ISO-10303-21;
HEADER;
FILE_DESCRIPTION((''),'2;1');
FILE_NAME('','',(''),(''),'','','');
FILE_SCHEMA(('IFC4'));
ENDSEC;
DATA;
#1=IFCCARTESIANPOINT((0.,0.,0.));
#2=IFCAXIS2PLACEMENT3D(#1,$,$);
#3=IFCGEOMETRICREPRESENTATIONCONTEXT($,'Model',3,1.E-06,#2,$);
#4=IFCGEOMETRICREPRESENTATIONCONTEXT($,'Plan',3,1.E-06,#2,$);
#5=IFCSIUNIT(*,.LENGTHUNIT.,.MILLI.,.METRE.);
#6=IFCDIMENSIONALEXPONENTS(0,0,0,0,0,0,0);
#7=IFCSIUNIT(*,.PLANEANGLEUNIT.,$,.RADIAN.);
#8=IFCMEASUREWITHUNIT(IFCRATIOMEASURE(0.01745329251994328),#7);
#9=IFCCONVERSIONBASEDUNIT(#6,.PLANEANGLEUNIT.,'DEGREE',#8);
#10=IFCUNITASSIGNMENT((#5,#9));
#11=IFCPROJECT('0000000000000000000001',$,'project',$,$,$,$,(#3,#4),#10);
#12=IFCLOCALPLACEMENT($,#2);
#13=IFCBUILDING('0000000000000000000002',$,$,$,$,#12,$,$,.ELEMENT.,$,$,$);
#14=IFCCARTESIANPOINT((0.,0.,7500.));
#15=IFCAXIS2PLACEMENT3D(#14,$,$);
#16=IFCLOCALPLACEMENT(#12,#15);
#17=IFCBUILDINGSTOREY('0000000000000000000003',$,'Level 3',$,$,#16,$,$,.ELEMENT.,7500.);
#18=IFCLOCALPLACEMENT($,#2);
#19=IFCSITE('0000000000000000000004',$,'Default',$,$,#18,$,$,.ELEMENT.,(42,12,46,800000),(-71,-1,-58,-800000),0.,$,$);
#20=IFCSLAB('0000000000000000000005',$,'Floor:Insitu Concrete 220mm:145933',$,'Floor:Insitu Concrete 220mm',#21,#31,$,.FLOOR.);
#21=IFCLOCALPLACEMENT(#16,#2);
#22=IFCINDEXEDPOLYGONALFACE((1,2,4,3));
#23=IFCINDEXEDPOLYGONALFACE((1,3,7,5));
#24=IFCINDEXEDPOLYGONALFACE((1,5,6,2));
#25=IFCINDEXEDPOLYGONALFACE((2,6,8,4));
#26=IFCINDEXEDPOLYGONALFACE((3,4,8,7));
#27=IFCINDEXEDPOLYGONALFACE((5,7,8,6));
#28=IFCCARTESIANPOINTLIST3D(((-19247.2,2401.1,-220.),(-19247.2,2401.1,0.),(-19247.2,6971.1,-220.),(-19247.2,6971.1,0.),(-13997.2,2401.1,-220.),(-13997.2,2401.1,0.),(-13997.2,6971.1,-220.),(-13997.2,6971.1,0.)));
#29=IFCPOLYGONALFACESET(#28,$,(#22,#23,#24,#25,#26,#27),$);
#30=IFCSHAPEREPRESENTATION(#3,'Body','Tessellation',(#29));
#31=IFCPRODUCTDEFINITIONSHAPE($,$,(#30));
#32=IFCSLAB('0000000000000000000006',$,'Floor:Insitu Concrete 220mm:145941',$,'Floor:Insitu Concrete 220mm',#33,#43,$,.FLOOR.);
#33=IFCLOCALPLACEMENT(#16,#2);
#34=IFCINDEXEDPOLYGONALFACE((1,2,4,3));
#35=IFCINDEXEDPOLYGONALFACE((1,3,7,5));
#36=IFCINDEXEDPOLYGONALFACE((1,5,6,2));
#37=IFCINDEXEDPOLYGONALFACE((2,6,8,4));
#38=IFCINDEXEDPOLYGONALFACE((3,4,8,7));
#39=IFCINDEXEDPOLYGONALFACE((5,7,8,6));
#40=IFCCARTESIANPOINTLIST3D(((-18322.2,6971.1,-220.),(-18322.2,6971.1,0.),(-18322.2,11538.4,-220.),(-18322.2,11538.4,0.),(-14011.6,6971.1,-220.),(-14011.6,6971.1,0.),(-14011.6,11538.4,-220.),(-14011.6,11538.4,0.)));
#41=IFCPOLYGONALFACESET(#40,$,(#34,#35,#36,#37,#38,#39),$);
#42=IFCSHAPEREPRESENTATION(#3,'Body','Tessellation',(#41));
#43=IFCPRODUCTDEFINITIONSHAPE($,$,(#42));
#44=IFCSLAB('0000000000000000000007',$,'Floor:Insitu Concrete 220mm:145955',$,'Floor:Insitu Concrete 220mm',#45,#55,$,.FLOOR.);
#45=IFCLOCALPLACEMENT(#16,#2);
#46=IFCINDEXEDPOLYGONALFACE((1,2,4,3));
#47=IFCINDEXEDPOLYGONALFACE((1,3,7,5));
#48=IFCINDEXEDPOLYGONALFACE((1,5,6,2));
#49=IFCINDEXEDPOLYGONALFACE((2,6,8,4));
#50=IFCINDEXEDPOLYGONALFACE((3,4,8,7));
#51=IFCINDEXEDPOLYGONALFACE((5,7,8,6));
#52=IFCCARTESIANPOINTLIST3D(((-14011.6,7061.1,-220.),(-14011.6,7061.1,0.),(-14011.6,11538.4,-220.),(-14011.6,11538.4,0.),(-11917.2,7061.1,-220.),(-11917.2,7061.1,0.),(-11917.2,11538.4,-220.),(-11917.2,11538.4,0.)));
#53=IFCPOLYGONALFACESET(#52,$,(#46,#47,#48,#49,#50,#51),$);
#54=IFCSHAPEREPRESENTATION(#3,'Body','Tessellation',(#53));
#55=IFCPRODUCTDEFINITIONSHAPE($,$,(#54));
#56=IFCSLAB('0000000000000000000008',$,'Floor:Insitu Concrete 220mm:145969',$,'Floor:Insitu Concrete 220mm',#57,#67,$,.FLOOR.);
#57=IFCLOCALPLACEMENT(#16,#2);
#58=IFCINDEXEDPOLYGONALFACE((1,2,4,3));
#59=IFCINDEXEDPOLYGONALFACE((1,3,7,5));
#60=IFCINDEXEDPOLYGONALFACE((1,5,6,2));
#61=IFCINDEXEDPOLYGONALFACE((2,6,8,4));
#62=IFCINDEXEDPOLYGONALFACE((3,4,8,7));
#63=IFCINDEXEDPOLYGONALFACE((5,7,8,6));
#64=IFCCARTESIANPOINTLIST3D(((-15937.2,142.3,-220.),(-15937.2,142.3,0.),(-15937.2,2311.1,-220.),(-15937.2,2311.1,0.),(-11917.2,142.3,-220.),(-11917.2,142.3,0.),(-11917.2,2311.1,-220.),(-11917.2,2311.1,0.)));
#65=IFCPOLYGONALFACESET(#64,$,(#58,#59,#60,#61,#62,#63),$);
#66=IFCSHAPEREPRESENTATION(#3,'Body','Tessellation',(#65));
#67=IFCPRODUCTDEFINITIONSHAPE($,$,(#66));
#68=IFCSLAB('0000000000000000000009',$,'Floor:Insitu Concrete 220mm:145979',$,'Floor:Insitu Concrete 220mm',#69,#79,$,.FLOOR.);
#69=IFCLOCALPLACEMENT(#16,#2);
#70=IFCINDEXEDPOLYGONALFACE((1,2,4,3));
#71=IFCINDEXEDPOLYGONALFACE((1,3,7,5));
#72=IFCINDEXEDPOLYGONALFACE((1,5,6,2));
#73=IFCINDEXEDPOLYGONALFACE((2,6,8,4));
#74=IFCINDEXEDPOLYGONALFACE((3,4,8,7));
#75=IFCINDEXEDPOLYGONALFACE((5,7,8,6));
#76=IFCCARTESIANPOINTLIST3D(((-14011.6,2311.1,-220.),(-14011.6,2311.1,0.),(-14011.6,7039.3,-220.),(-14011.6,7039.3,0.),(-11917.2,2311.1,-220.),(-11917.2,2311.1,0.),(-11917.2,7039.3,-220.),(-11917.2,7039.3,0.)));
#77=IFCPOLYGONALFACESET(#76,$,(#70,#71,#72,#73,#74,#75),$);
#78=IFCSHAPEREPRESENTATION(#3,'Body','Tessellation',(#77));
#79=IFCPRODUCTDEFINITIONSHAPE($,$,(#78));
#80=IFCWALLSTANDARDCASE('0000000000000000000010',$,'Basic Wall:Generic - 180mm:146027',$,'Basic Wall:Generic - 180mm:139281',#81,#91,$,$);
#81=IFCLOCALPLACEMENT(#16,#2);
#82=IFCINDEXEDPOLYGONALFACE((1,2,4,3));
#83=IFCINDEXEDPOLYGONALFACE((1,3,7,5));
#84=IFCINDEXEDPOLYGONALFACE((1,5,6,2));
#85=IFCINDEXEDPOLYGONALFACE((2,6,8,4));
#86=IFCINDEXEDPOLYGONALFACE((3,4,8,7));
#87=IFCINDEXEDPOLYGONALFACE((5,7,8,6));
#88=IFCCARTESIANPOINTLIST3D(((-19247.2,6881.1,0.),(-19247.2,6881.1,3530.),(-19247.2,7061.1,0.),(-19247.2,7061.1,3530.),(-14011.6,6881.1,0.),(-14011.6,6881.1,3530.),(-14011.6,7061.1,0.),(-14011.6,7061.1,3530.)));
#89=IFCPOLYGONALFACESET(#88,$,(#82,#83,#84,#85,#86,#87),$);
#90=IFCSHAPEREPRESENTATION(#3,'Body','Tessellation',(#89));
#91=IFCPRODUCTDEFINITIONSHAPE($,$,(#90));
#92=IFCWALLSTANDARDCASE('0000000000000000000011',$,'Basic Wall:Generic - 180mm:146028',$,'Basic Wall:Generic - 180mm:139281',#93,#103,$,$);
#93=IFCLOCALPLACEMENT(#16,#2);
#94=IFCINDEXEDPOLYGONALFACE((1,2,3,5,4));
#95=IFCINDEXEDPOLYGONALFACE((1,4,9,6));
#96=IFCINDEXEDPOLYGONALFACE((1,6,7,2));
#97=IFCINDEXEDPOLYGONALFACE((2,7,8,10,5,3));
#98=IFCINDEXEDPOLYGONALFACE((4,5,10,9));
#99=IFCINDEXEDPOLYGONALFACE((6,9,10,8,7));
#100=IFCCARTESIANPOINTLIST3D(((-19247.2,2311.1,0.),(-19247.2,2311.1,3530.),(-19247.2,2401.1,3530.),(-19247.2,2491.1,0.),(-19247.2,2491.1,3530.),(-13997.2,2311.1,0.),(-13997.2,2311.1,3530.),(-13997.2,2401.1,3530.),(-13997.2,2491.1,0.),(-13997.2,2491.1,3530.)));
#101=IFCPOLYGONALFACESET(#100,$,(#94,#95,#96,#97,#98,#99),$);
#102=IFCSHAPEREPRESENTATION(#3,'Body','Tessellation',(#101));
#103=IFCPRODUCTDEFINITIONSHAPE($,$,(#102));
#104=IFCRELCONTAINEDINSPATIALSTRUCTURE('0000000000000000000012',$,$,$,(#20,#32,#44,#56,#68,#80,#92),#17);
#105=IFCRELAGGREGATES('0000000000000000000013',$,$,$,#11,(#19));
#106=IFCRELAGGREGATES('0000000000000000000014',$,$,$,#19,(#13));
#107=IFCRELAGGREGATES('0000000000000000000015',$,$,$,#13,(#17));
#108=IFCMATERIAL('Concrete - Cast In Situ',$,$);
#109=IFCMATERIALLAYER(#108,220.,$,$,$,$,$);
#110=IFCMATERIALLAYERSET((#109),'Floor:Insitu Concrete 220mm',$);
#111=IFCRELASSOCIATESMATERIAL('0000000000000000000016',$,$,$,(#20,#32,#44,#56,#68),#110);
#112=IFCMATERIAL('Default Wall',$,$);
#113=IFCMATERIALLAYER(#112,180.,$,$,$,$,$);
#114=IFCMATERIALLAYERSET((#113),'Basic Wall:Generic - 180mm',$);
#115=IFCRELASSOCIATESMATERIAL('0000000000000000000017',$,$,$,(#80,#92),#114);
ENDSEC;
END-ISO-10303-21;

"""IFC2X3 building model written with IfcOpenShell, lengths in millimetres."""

from ifc_helpers import new_model, entity, si_unit, converted_unit, frame, frame_2d, origin, place, context, project, spatial, polyline, rectangle, extrude, clip, bounded_halfspace, material, layer, layer_set, layer_usage, element, save


model = new_model("IFC2X3")

# Units and contexts
model_context = context("Model", 3, precision=1e-06, world=origin())
plan_context = context("Plan", 3, precision=1e-06, world=origin())
ifc_project = project(units=[si_unit("LENGTHUNIT", "METRE", prefix="MILLI"), converted_unit("PLANEANGLEUNIT", "DEGREE", entity("IfcRatioMeasure", 0.01745329251994328), si_unit("PLANEANGLEUNIT", "RADIAN"), dimensions=[0, 0, 0, 0, 0, 0, 0])], contexts=[model_context, plan_context])

# Site, building, storey
site_placement = place(None, origin())
site = spatial("IfcSite", under=ifc_project, at=site_placement, Name="Default", CompositionType="ELEMENT", RefLatitude=(42, 12, 46, 800000), RefLongitude=(-71, -1, -58, -800000), RefElevation=0.0)
building_placement = place(None, origin())
building = spatial("IfcBuilding", under=site, at=building_placement, CompositionType="ELEMENT")
storey_placement = place(building_placement, frame((0.0, 0.0, 7500.0)))
storey = spatial("IfcBuildingStorey", under=building, at=storey_placement, Name="Level 3", CompositionType="ELEMENT", Elevation=7500.0)

# Slabs
ifc_material_1 = material(Name="Concrete - Cast In Situ")
ifc_layer_1 = layer(ifc_material_1, 220.0)
ifc_layer_set_1 = layer_set([ifc_layer_1], Name="Floor:Insitu Concrete 220mm")
ifc_layer_usage_1 = layer_usage(ifc_layer_set_1, "AXIS3", "POSITIVE", 0.0)
slab_1_placement = place(storey_placement, frame((-19247.2, 2401.1, -220.0)))
element("IfcSlab", 1, at=slab_1_placement, inside=storey, material=ifc_layer_usage_1, Name="Floor:Insitu Concrete 220mm:145933", ObjectType="Floor:Insitu Concrete 220mm", PredefinedType="FLOOR", context=model_context, shape_type="SweptSolid", body=[
    extrude(rectangle(XDim=4570.0, YDim=5250.0, at=frame_2d((16622.2, 4686.1), x_axis=(0.0, -1.0))), frame((19247.2, -2401.1, 220.0), z_axis=(0.0, 0.0, -1.0), x_axis=(-1.0, 0.0, 0.0)), (0.0, 0.0, 1.0), 220.0),
])
ifc_layer_usage_2 = layer_usage(ifc_layer_set_1, "AXIS3", "POSITIVE", 0.0)
slab_2_placement = place(storey_placement, frame((-18322.2, 6971.1, -220.0)))
element("IfcSlab", 2, at=slab_2_placement, inside=storey, material=ifc_layer_usage_2, Name="Floor:Insitu Concrete 220mm:145941", ObjectType="Floor:Insitu Concrete 220mm", PredefinedType="FLOOR", context=model_context, shape_type="SweptSolid", body=[
    extrude(rectangle(XDim=4567.3, YDim=4310.6, at=frame_2d((16166.9, 9254.7), x_axis=(0.0, -1.0))), frame((18322.2, -6971.1, 220.0), z_axis=(0.0, 0.0, -1.0), x_axis=(-1.0, 0.0, 0.0)), (0.0, 0.0, 1.0), 220.0),
])
ifc_layer_usage_3 = layer_usage(ifc_layer_set_1, "AXIS3", "POSITIVE", 0.0)
slab_3_placement = place(storey_placement, frame((-14011.6, 7061.1, -220.0)))
element("IfcSlab", 3, at=slab_3_placement, inside=storey, material=ifc_layer_usage_3, Name="Floor:Insitu Concrete 220mm:145955", ObjectType="Floor:Insitu Concrete 220mm", PredefinedType="FLOOR", context=model_context, shape_type="SweptSolid", body=[
    extrude(rectangle(XDim=4477.3, YDim=2094.4, at=frame_2d((12964.4, 9299.7), x_axis=(0.0, -1.0))), frame((14011.6, -7061.1, 220.0), z_axis=(0.0, 0.0, -1.0), x_axis=(-1.0, 0.0, 0.0)), (0.0, 0.0, 1.0), 220.0),
])
ifc_layer_usage_4 = layer_usage(ifc_layer_set_1, "AXIS3", "POSITIVE", 0.0)
slab_4_placement = place(storey_placement, frame((-15937.2, 142.3, -220.0)))
element("IfcSlab", 4, at=slab_4_placement, inside=storey, material=ifc_layer_usage_4, Name="Floor:Insitu Concrete 220mm:145969", ObjectType="Floor:Insitu Concrete 220mm", PredefinedType="FLOOR", context=model_context, shape_type="SweptSolid", body=[
    extrude(rectangle(XDim=2168.8, YDim=4020.0, at=frame_2d((13927.2, 1226.7), x_axis=(0.0, -1.0))), frame((15937.2, -142.3, 220.0), z_axis=(0.0, 0.0, -1.0), x_axis=(-1.0, 0.0, 0.0)), (0.0, 0.0, 1.0), 220.0),
])
ifc_layer_usage_5 = layer_usage(ifc_layer_set_1, "AXIS3", "POSITIVE", 0.0)
slab_5_placement = place(storey_placement, frame((-14011.6, 2311.1, -220.0)))
element("IfcSlab", 5, at=slab_5_placement, inside=storey, material=ifc_layer_usage_5, Name="Floor:Insitu Concrete 220mm:145979", ObjectType="Floor:Insitu Concrete 220mm", PredefinedType="FLOOR", context=model_context, shape_type="SweptSolid", body=[
    extrude(rectangle(XDim=4728.2, YDim=2094.4, at=frame_2d((12964.4, 4675.2), x_axis=(0.0, -1.0))), frame((14011.6, -2311.1, 220.0), z_axis=(0.0, 0.0, -1.0), x_axis=(-1.0, 0.0, 0.0)), (0.0, 0.0, 1.0), 220.0),
])

# Walls
ifc_material_2 = material(Name="Default Wall")
ifc_layer_2 = layer(ifc_material_2, 180.0)
ifc_layer_set_2 = layer_set([ifc_layer_2], Name="Basic Wall:Generic - 180mm")
ifc_layer_usage_6 = layer_usage(ifc_layer_set_2, "AXIS2", "POSITIVE", -90.0)
wall_1_placement = place(storey_placement, frame((-19247.2, 6971.1, 0.0)))
element("IfcWallStandardCase", 6, at=wall_1_placement, inside=storey, material=ifc_layer_usage_6, Name="Basic Wall:Generic - 180mm:146027", ObjectType="Basic Wall:Generic - 180mm:139281", context=model_context, shape_type="Clipping", body=[
    clip(extrude(rectangle(XDim=5235.6, YDim=180.0, at=frame_2d((2617.8, 0.0), x_axis=(-1.0, 0.0))), origin(), (0.0, 0.0, 1.0), 3750.0), bounded_halfspace(frame((0.0, -90.0, 3530.0), z_axis=(0.0, 0.0, 1.0), x_axis=(0.0, 1.0, 0.0)), False, frame((0.0, -90.0, 3530.0)), polyline([(0.0, 0.0), (5235.6, 0.0), (5235.6, 90.0), (5235.6, 180.0), (0.0, 180.0), (0.0, 90.0), (0.0, 0.0)]))),
])
ifc_layer_usage_7 = layer_usage(ifc_layer_set_2, "AXIS2", "POSITIVE", -90.0)
wall_2_placement = place(storey_placement, frame((-13997.2, 2401.1, 0.0), z_axis=(0.0, 0.0, 1.0), x_axis=(-1.0, 0.0, 0.0)))
element("IfcWallStandardCase", 7, at=wall_2_placement, inside=storey, material=ifc_layer_usage_7, Name="Basic Wall:Generic - 180mm:146028", ObjectType="Basic Wall:Generic - 180mm:139281", context=model_context, shape_type="Clipping", body=[
    clip(clip(clip(extrude(rectangle(XDim=5250.0, YDim=180.0, at=frame_2d((2625.0, 0.0), x_axis=(-1.0, 0.0))), origin(), (0.0, 0.0, 1.0), 3750.0), bounded_halfspace(frame((0.0, -90.0, 3530.0), z_axis=(0.0, 0.0, -1.0), x_axis=(0.0, 1.0, 0.0)), True, frame((0.0, -90.0, 3530.0)), polyline([(0.0, 0.0), (5250.0, 0.0), (5250.0, 90.0), (0.0, 90.0), (0.0, 0.0)]))), bounded_halfspace(frame((0.0, -90.0, 3530.0), z_axis=(0.0, 0.0, -1.0), x_axis=(0.0, 1.0, 0.0)), True, frame((0.0, -90.0, 3530.0)), polyline([(0.0, 0.0), (5250.0, 0.0), (5250.0, 90.0), (0.0, 90.0), (0.0, 0.0)]))), bounded_halfspace(frame((5250.0, 0.0, 3530.0), z_axis=(0.0, 0.0, 1.0), x_axis=(0.0, 1.0, 0.0)), False, frame((5250.0, 0.0, 3530.0)), polyline([(0.0, 0.0), (0.0, 90.0), (-5250.0, 90.0), (-5250.0, 0.0), (0.0, 0.0)]))),
])

save(model, "model.ifc")
